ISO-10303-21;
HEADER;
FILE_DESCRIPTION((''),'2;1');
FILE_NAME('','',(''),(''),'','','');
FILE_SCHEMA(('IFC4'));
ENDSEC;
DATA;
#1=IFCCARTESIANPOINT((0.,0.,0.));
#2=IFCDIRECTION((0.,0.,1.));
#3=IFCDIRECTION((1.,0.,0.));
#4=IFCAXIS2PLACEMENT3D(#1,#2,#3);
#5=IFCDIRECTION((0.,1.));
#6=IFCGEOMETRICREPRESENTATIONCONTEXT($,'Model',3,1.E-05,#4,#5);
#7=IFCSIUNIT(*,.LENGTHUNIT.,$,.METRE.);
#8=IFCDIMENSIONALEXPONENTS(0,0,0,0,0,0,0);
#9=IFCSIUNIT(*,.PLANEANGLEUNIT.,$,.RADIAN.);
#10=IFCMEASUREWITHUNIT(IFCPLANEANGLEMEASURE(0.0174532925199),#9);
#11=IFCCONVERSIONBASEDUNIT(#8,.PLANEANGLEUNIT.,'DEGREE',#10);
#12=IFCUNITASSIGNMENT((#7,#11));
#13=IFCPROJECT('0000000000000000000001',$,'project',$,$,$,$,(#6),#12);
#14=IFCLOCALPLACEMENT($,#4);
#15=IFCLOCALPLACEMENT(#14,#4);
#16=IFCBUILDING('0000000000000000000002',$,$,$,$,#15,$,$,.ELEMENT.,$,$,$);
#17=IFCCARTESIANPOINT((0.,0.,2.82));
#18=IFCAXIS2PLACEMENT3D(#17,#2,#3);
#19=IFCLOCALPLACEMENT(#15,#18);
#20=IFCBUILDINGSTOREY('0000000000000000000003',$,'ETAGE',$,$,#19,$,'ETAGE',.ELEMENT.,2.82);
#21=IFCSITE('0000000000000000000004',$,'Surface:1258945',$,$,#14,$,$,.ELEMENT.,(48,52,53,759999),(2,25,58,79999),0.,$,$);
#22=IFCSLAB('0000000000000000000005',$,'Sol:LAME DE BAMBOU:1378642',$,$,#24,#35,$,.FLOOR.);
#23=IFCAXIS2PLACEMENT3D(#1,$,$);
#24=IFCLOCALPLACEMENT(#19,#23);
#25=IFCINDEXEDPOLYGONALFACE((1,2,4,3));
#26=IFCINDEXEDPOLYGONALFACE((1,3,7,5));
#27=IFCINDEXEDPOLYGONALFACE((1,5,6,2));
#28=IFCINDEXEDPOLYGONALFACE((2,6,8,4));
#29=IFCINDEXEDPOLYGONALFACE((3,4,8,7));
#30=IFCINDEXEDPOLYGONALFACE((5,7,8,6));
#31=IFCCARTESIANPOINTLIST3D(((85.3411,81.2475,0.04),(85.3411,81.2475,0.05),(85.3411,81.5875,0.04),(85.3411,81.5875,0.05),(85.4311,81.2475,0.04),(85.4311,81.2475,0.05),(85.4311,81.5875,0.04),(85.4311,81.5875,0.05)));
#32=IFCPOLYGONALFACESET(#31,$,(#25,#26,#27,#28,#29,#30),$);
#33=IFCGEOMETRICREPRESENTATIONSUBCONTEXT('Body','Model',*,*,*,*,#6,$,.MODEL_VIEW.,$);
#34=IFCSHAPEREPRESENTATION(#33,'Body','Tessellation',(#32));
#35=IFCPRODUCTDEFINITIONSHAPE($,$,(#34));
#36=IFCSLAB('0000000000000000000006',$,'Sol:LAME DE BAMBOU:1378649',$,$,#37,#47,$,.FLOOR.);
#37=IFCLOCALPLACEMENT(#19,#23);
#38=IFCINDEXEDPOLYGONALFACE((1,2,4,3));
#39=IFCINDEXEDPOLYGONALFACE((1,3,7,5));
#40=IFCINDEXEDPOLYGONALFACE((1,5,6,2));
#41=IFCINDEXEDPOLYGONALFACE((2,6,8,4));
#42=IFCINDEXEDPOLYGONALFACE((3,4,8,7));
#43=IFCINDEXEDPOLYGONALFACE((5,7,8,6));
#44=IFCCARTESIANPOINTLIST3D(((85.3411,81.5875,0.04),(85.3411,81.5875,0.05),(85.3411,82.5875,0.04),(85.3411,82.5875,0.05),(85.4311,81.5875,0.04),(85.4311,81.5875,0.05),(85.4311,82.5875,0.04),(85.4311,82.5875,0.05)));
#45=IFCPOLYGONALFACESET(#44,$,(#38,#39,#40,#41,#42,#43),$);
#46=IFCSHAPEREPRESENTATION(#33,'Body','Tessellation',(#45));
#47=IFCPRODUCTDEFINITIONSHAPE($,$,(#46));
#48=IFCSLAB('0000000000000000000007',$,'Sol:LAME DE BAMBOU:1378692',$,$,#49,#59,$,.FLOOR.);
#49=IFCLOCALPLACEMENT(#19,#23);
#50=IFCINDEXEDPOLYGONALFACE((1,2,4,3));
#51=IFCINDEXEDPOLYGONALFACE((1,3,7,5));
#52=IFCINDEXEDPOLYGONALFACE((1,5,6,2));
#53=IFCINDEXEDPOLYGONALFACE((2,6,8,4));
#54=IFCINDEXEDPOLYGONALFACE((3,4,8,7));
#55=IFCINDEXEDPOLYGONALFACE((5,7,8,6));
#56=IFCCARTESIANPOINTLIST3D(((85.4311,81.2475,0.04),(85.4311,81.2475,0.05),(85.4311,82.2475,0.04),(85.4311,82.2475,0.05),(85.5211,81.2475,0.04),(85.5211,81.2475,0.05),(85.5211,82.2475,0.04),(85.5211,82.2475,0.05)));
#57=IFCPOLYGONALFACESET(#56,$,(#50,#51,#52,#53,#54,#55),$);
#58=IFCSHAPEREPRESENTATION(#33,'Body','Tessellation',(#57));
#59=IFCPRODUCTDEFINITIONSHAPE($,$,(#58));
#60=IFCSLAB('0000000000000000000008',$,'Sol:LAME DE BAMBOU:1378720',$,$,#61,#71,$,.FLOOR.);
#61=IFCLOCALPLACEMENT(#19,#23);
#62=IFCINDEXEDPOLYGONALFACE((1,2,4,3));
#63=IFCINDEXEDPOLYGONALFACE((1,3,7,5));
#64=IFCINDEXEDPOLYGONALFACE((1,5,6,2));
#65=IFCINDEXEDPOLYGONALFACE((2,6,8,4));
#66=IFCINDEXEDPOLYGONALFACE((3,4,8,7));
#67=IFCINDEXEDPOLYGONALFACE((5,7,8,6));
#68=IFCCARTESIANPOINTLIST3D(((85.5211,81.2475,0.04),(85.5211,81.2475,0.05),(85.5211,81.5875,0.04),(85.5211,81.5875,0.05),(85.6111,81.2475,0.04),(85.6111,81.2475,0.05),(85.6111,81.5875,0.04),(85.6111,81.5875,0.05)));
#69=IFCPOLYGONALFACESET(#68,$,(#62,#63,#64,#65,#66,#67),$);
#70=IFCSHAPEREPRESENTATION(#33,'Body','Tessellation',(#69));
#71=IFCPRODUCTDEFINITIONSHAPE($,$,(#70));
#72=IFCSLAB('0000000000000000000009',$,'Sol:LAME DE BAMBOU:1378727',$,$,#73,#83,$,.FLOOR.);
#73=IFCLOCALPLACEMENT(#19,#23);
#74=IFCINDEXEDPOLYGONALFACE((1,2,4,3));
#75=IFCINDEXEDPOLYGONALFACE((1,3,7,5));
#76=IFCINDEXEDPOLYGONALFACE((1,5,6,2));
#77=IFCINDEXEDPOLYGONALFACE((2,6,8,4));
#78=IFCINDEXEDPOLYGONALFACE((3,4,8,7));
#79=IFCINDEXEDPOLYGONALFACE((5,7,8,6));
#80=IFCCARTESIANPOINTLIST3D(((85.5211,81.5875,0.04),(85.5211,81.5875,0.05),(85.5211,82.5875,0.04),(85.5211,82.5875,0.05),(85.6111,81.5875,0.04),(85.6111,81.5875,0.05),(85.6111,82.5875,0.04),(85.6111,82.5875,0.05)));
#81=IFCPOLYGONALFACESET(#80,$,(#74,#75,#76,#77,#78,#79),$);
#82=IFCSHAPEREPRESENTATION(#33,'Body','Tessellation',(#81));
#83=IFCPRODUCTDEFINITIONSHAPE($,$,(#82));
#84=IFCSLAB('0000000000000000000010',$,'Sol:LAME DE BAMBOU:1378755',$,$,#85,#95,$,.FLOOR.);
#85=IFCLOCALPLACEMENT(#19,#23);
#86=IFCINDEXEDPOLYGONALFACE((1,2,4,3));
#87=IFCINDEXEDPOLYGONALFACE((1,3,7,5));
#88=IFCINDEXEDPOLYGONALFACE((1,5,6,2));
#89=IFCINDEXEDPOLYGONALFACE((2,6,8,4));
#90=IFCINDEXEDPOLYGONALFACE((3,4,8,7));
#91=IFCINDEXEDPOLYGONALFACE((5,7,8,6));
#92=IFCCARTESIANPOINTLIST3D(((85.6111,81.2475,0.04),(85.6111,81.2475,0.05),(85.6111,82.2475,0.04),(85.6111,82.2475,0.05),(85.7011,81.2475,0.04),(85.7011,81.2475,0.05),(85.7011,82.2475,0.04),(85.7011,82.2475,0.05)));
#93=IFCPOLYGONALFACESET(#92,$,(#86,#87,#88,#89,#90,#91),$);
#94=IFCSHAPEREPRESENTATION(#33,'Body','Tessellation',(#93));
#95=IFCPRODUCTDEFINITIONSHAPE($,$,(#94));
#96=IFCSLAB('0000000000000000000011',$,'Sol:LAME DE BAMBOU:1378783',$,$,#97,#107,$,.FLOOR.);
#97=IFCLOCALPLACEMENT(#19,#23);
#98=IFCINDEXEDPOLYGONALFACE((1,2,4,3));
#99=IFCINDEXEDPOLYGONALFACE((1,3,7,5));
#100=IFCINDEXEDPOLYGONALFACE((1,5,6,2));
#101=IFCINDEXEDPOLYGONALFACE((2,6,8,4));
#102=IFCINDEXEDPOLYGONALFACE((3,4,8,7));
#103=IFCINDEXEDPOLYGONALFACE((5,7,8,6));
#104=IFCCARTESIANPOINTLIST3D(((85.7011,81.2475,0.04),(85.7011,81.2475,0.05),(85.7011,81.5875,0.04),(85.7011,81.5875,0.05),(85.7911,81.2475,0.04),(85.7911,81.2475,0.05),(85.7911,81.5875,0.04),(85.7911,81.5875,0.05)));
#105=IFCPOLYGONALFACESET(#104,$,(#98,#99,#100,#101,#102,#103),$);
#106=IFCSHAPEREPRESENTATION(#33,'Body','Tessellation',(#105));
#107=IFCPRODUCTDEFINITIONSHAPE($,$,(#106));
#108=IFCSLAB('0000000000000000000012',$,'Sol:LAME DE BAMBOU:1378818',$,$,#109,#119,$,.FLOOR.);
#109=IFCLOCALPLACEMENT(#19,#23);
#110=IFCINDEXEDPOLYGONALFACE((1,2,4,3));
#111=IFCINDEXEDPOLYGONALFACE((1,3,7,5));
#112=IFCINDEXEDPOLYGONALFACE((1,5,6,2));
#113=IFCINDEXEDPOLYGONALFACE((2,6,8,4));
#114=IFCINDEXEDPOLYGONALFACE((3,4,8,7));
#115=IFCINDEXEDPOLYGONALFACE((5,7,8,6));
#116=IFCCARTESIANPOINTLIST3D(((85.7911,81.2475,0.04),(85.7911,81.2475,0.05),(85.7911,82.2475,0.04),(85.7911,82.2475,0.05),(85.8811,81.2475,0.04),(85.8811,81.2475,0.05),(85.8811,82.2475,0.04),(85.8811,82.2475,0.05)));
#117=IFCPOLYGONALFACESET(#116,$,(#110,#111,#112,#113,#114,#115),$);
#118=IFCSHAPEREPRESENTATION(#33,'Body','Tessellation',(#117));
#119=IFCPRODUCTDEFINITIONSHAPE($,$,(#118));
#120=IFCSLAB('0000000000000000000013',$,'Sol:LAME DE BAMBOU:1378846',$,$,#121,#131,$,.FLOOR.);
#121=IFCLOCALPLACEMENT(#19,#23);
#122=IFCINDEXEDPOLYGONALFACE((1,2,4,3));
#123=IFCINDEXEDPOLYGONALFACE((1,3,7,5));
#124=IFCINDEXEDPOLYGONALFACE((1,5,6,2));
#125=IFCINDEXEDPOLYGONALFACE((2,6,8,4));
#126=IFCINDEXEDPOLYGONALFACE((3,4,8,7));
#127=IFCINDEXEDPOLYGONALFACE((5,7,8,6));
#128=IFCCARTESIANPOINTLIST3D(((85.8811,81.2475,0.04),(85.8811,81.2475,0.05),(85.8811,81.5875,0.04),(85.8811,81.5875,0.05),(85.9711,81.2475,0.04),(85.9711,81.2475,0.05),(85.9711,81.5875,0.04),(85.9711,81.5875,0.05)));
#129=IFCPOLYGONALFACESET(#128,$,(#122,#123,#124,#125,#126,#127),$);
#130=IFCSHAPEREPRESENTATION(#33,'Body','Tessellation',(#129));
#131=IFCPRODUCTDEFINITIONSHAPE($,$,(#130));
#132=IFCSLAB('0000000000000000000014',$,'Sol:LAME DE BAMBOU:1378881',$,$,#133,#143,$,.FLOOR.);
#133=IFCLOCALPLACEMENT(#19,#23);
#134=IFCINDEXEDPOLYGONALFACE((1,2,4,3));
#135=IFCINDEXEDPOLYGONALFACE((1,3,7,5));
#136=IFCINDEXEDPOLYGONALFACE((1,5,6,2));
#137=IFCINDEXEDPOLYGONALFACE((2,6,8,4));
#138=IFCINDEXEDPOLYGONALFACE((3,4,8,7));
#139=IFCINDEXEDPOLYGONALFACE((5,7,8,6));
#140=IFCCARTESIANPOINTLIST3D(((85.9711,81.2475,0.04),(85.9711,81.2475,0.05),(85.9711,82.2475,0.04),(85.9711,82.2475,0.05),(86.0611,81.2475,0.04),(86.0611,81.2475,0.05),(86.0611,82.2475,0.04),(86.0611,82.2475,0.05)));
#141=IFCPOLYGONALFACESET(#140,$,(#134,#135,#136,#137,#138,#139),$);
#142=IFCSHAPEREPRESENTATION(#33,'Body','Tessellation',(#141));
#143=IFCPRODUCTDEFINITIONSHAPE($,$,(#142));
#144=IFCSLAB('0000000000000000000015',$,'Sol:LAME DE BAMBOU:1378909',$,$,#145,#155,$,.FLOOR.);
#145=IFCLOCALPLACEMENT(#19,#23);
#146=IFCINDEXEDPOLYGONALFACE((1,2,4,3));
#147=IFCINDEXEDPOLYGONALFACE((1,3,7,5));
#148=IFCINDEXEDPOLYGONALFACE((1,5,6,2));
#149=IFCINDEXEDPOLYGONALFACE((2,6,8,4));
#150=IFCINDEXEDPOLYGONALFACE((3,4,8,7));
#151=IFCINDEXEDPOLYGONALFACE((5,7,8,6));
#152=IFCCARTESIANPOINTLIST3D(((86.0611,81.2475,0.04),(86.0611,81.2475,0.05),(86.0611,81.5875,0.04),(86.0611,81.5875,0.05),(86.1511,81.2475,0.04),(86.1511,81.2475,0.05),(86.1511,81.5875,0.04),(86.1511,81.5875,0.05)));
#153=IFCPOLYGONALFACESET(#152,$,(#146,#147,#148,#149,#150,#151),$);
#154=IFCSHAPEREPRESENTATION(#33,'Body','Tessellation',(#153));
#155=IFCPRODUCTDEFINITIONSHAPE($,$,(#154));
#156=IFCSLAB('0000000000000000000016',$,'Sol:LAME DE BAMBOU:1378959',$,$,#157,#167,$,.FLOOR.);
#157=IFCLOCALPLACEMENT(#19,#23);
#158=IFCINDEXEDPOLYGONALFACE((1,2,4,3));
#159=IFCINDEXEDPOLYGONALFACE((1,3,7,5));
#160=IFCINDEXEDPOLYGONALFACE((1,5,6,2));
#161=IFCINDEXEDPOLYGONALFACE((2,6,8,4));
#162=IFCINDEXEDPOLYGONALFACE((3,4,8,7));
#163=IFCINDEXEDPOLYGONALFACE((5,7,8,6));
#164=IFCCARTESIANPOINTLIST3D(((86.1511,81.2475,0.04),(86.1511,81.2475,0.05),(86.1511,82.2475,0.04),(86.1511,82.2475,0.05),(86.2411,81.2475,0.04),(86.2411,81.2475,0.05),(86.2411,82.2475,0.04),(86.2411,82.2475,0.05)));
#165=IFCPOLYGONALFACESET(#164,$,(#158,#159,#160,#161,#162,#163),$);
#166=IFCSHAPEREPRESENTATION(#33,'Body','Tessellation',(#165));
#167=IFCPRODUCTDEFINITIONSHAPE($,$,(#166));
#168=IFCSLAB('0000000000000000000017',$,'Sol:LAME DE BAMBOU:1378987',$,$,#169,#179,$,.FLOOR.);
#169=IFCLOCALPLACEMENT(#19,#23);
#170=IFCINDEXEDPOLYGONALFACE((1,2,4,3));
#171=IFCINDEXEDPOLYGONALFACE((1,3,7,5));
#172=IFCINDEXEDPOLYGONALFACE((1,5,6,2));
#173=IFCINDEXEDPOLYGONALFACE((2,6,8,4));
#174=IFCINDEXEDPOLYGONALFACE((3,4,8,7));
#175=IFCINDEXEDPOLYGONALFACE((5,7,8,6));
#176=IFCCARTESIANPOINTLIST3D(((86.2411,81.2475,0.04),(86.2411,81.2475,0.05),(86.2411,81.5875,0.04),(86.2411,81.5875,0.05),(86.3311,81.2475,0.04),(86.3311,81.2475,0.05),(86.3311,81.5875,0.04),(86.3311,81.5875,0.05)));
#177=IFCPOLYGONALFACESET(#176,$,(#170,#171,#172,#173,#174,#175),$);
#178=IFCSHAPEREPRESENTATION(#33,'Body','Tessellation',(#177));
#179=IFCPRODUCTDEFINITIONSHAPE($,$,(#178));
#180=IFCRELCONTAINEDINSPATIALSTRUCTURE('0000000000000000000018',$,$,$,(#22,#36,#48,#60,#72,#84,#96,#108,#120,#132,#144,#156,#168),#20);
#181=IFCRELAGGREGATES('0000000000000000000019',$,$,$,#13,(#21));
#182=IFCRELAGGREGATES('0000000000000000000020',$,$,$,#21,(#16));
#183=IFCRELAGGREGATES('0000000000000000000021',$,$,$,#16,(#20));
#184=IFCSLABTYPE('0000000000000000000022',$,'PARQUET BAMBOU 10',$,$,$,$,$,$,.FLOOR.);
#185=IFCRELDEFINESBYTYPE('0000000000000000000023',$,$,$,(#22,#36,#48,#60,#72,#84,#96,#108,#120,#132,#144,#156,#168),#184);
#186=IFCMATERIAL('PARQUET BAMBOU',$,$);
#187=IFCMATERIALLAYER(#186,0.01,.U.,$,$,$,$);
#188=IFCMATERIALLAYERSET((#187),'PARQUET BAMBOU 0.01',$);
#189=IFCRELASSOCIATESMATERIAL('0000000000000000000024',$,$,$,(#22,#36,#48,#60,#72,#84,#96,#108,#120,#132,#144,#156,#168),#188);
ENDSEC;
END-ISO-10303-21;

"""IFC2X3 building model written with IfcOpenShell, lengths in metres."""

from ifc_helpers import new_model, entity, si_unit, converted_unit, direction, frame, origin_with_axes, place, context, subcontext, project, spatial, polyline, outline, extrude, material, layer, layer_set, layer_usage, type_object, element, save


model = new_model("IFC2X3")

# Units and contexts
model_context = context("Model", 3, precision=1e-05, world=origin_with_axes(), true_north=direction((0.0, 1.0)))
body_context = subcontext(model_context, "Body", "Model", "MODEL_VIEW")
ifc_project = project(units=[si_unit("LENGTHUNIT", "METRE"), converted_unit("PLANEANGLEUNIT", "DEGREE", entity("IfcPlaneAngleMeasure", 0.0174532925199), si_unit("PLANEANGLEUNIT", "RADIAN"), dimensions=[0, 0, 0, 0, 0, 0, 0])], contexts=[model_context])

# Site, building, storey
site_placement = place(None, origin_with_axes())
site = spatial("IfcSite", under=ifc_project, at=site_placement, Name="Surface:1258945", CompositionType="ELEMENT", RefLatitude=(48, 52, 53, 759999), RefLongitude=(2, 25, 58, 79999), RefElevation=0.0)
building_placement = place(site_placement, origin_with_axes())
building = spatial("IfcBuilding", under=site, at=building_placement, CompositionType="ELEMENT")
storey_placement = place(building_placement, frame((0.0, 0.0, 2.82), z_axis=(0.0, 0.0, 1.0), x_axis=(1.0, 0.0, 0.0)))
storey = spatial("IfcBuildingStorey", under=building, at=storey_placement, Name="ETAGE", LongName="ETAGE", CompositionType="ELEMENT", Elevation=2.82)

# Slabs
ifc_material = material(Name="PARQUET BAMBOU")
ifc_layer = layer(ifc_material, 0.01, ventilated="UNKNOWN")
ifc_layer_set = layer_set([ifc_layer], Name="PARQUET BAMBOU 0.01")
ifc_layer_usage_1 = layer_usage(ifc_layer_set, "AXIS3", "NEGATIVE", 0.01)
slab_type = type_object("IfcSlabType", Name="PARQUET BAMBOU 10", PredefinedType="FLOOR")
slab_1_placement = place(storey_placement, frame((85.3411, 81.5875, 0.05), z_axis=(0.0, 0.0, 1.0), x_axis=(1.0, 0.0, 0.0)))
element("IfcSlab", 1, at=slab_1_placement, inside=storey, type_object=slab_type, material=ifc_layer_usage_1, Name="Sol:LAME DE BAMBOU:1378642", PredefinedType="FLOOR", context=body_context, shape_type="SweptSolid", body=[
    extrude(outline(polyline([(0.0, 0.0), (0.0, -0.34), (0.09, -0.34), (0.09, 0.0), (0.0, 0.0)])), frame((0.0, 0.0, -0.01), z_axis=(0.0, 0.0, 1.0), x_axis=(1.0, 0.0, 0.0)), (0.0, 0.0, 1.0), 0.01),
])
ifc_layer_usage_2 = layer_usage(ifc_layer_set, "AXIS3", "NEGATIVE", 0.01)
slab_2_placement = place(storey_placement, frame((85.3411, 82.5875, 0.05), z_axis=(0.0, 0.0, 1.0), x_axis=(1.0, 0.0, 0.0)))
element("IfcSlab", 2, at=slab_2_placement, inside=storey, type_object=slab_type, material=ifc_layer_usage_2, Name="Sol:LAME DE BAMBOU:1378649", PredefinedType="FLOOR", context=body_context, shape_type="SweptSolid", body=[
    extrude(outline(polyline([(0.0, 0.0), (0.0, -1.0), (0.09, -1.0), (0.09, 0.0), (0.0, 0.0)])), frame((0.0, 0.0, -0.01), z_axis=(0.0, 0.0, 1.0), x_axis=(1.0, 0.0, 0.0)), (0.0, 0.0, 1.0), 0.01),
])
ifc_layer_usage_3 = layer_usage(ifc_layer_set, "AXIS3", "NEGATIVE", 0.01)
slab_3_placement = place(storey_placement, frame((85.4311, 82.2475, 0.05), z_axis=(0.0, 0.0, 1.0), x_axis=(1.0, 0.0, 0.0)))
element("IfcSlab", 3, at=slab_3_placement, inside=storey, type_object=slab_type, material=ifc_layer_usage_3, Name="Sol:LAME DE BAMBOU:1378692", PredefinedType="FLOOR", context=body_context, shape_type="SweptSolid", body=[
    extrude(outline(polyline([(0.0, 0.0), (0.0, -1.0), (0.09, -1.0), (0.09, 0.0), (0.0, 0.0)])), frame((0.0, 0.0, -0.01), z_axis=(0.0, 0.0, 1.0), x_axis=(1.0, 0.0, 0.0)), (0.0, 0.0, 1.0), 0.01),
])
ifc_layer_usage_4 = layer_usage(ifc_layer_set, "AXIS3", "NEGATIVE", 0.01)
slab_4_placement = place(storey_placement, frame((85.5211, 81.5875, 0.05), z_axis=(0.0, 0.0, 1.0), x_axis=(1.0, 0.0, 0.0)))
element("IfcSlab", 4, at=slab_4_placement, inside=storey, type_object=slab_type, material=ifc_layer_usage_4, Name="Sol:LAME DE BAMBOU:1378720", PredefinedType="FLOOR", context=body_context, shape_type="SweptSolid", body=[
    extrude(outline(polyline([(0.0, 0.0), (0.0, -0.34), (0.09, -0.34), (0.09, 0.0), (0.0, 0.0)])), frame((0.0, 0.0, -0.01), z_axis=(0.0, 0.0, 1.0), x_axis=(1.0, 0.0, 0.0)), (0.0, 0.0, 1.0), 0.01),
])
ifc_layer_usage_5 = layer_usage(ifc_layer_set, "AXIS3", "NEGATIVE", 0.01)
slab_5_placement = place(storey_placement, frame((85.5211, 82.5875, 0.05), z_axis=(0.0, 0.0, 1.0), x_axis=(1.0, 0.0, 0.0)))
element("IfcSlab", 5, at=slab_5_placement, inside=storey, type_object=slab_type, material=ifc_layer_usage_5, Name="Sol:LAME DE BAMBOU:1378727", PredefinedType="FLOOR", context=body_context, shape_type="SweptSolid", body=[
    extrude(outline(polyline([(0.0, 0.0), (0.0, -1.0), (0.09, -1.0), (0.09, 0.0), (0.0, 0.0)])), frame((0.0, 0.0, -0.01), z_axis=(0.0, 0.0, 1.0), x_axis=(1.0, 0.0, 0.0)), (0.0, 0.0, 1.0), 0.01),
])
ifc_layer_usage_6 = layer_usage(ifc_layer_set, "AXIS3", "NEGATIVE", 0.01)
slab_6_placement = place(storey_placement, frame((85.6111, 82.2475, 0.05), z_axis=(0.0, 0.0, 1.0), x_axis=(1.0, 0.0, 0.0)))
element("IfcSlab", 6, at=slab_6_placement, inside=storey, type_object=slab_type, material=ifc_layer_usage_6, Name="Sol:LAME DE BAMBOU:1378755", PredefinedType="FLOOR", context=body_context, shape_type="SweptSolid", body=[
    extrude(outline(polyline([(0.0, 0.0), (0.0, -1.0), (0.09, -1.0), (0.09, 0.0), (0.0, 0.0)])), frame((0.0, 0.0, -0.01), z_axis=(0.0, 0.0, 1.0), x_axis=(1.0, 0.0, 0.0)), (0.0, 0.0, 1.0), 0.01),
])
ifc_layer_usage_7 = layer_usage(ifc_layer_set, "AXIS3", "NEGATIVE", 0.01)
slab_7_placement = place(storey_placement, frame((85.7011, 81.5875, 0.05), z_axis=(0.0, 0.0, 1.0), x_axis=(1.0, 0.0, 0.0)))
element("IfcSlab", 7, at=slab_7_placement, inside=storey, type_object=slab_type, material=ifc_layer_usage_7, Name="Sol:LAME DE BAMBOU:1378783", PredefinedType="FLOOR", context=body_context, shape_type="SweptSolid", body=[
    extrude(outline(polyline([(0.0, 0.0), (0.0, -0.34), (0.09, -0.34), (0.09, 0.0), (0.0, 0.0)])), frame((0.0, 0.0, -0.01), z_axis=(0.0, 0.0, 1.0), x_axis=(1.0, 0.0, 0.0)), (0.0, 0.0, 1.0), 0.01),
])
ifc_layer_usage_8 = layer_usage(ifc_layer_set, "AXIS3", "NEGATIVE", 0.01)
slab_8_placement = place(storey_placement, frame((85.7911, 82.2475, 0.05), z_axis=(0.0, 0.0, 1.0), x_axis=(1.0, 0.0, 0.0)))
element("IfcSlab", 8, at=slab_8_placement, inside=storey, type_object=slab_type, material=ifc_layer_usage_8, Name="Sol:LAME DE BAMBOU:1378818", PredefinedType="FLOOR", context=body_context, shape_type="SweptSolid", body=[
    extrude(outline(polyline([(0.0, 0.0), (0.0, -1.0), (0.09, -1.0), (0.09, 0.0), (0.0, 0.0)])), frame((0.0, 0.0, -0.01), z_axis=(0.0, 0.0, 1.0), x_axis=(1.0, 0.0, 0.0)), (0.0, 0.0, 1.0), 0.01),
])
ifc_layer_usage_9 = layer_usage(ifc_layer_set, "AXIS3", "NEGATIVE", 0.01)
slab_9_placement = place(storey_placement, frame((85.8811, 81.5875, 0.05), z_axis=(0.0, 0.0, 1.0), x_axis=(1.0, 0.0, 0.0)))
element("IfcSlab", 9, at=slab_9_placement, inside=storey, type_object=slab_type, material=ifc_layer_usage_9, Name="Sol:LAME DE BAMBOU:1378846", PredefinedType="FLOOR", context=body_context, shape_type="SweptSolid", body=[
    extrude(outline(polyline([(0.0, 0.0), (0.0, -0.34), (0.09, -0.34), (0.09, 0.0), (0.0, 0.0)])), frame((0.0, 0.0, -0.01), z_axis=(0.0, 0.0, 1.0), x_axis=(1.0, 0.0, 0.0)), (0.0, 0.0, 1.0), 0.01),
])
ifc_layer_usage_10 = layer_usage(ifc_layer_set, "AXIS3", "NEGATIVE", 0.01)
slab_10_placement = place(storey_placement, frame((85.9711, 82.2475, 0.05), z_axis=(0.0, 0.0, 1.0), x_axis=(1.0, 0.0, 0.0)))
element("IfcSlab", 10, at=slab_10_placement, inside=storey, type_object=slab_type, material=ifc_layer_usage_10, Name="Sol:LAME DE BAMBOU:1378881", PredefinedType="FLOOR", context=body_context, shape_type="SweptSolid", body=[
    extrude(outline(polyline([(0.0, 0.0), (0.0, -1.0), (0.09, -1.0), (0.09, 0.0), (0.0, 0.0)])), frame((0.0, 0.0, -0.01), z_axis=(0.0, 0.0, 1.0), x_axis=(1.0, 0.0, 0.0)), (0.0, 0.0, 1.0), 0.01),
])
ifc_layer_usage_11 = layer_usage(ifc_layer_set, "AXIS3", "NEGATIVE", 0.01)
slab_11_placement = place(storey_placement, frame((86.0611, 81.5875, 0.05), z_axis=(0.0, 0.0, 1.0), x_axis=(1.0, 0.0, 0.0)))
element("IfcSlab", 11, at=slab_11_placement, inside=storey, type_object=slab_type, material=ifc_layer_usage_11, Name="Sol:LAME DE BAMBOU:1378909", PredefinedType="FLOOR", context=body_context, shape_type="SweptSolid", body=[
    extrude(outline(polyline([(0.0, 0.0), (0.0, -0.34), (0.09, -0.34), (0.09, 0.0), (0.0, 0.0)])), frame((0.0, 0.0, -0.01), z_axis=(0.0, 0.0, 1.0), x_axis=(1.0, 0.0, 0.0)), (0.0, 0.0, 1.0), 0.01),
])
ifc_layer_usage_12 = layer_usage(ifc_layer_set, "AXIS3", "NEGATIVE", 0.01)
slab_12_placement = place(storey_placement, frame((86.1511, 82.2475, 0.05), z_axis=(0.0, 0.0, 1.0), x_axis=(1.0, 0.0, 0.0)))
element("IfcSlab", 12, at=slab_12_placement, inside=storey, type_object=slab_type, material=ifc_layer_usage_12, Name="Sol:LAME DE BAMBOU:1378959", PredefinedType="FLOOR", context=body_context, shape_type="SweptSolid", body=[
    extrude(outline(polyline([(0.0, 0.0), (0.0, -1.0), (0.09, -1.0), (0.09, 0.0), (0.0, 0.0)])), frame((0.0, 0.0, -0.01), z_axis=(0.0, 0.0, 1.0), x_axis=(1.0, 0.0, 0.0)), (0.0, 0.0, 1.0), 0.01),
])
ifc_layer_usage_13 = layer_usage(ifc_layer_set, "AXIS3", "NEGATIVE", 0.01)
slab_13_placement = place(storey_placement, frame((86.2411, 81.5875, 0.05), z_axis=(0.0, 0.0, 1.0), x_axis=(1.0, 0.0, 0.0)))
element("IfcSlab", 13, at=slab_13_placement, inside=storey, type_object=slab_type, material=ifc_layer_usage_13, Name="Sol:LAME DE BAMBOU:1378987", PredefinedType="FLOOR", context=body_context, shape_type="SweptSolid", body=[
    extrude(outline(polyline([(0.0, 0.0), (0.0, -0.34), (0.09, -0.34), (0.09, 0.0), (0.0, 0.0)])), frame((0.0, 0.0, -0.01), z_axis=(0.0, 0.0, 1.0), x_axis=(1.0, 0.0, 0.0)), (0.0, 0.0, 1.0), 0.01),
])

save(model, "model.ifc")
